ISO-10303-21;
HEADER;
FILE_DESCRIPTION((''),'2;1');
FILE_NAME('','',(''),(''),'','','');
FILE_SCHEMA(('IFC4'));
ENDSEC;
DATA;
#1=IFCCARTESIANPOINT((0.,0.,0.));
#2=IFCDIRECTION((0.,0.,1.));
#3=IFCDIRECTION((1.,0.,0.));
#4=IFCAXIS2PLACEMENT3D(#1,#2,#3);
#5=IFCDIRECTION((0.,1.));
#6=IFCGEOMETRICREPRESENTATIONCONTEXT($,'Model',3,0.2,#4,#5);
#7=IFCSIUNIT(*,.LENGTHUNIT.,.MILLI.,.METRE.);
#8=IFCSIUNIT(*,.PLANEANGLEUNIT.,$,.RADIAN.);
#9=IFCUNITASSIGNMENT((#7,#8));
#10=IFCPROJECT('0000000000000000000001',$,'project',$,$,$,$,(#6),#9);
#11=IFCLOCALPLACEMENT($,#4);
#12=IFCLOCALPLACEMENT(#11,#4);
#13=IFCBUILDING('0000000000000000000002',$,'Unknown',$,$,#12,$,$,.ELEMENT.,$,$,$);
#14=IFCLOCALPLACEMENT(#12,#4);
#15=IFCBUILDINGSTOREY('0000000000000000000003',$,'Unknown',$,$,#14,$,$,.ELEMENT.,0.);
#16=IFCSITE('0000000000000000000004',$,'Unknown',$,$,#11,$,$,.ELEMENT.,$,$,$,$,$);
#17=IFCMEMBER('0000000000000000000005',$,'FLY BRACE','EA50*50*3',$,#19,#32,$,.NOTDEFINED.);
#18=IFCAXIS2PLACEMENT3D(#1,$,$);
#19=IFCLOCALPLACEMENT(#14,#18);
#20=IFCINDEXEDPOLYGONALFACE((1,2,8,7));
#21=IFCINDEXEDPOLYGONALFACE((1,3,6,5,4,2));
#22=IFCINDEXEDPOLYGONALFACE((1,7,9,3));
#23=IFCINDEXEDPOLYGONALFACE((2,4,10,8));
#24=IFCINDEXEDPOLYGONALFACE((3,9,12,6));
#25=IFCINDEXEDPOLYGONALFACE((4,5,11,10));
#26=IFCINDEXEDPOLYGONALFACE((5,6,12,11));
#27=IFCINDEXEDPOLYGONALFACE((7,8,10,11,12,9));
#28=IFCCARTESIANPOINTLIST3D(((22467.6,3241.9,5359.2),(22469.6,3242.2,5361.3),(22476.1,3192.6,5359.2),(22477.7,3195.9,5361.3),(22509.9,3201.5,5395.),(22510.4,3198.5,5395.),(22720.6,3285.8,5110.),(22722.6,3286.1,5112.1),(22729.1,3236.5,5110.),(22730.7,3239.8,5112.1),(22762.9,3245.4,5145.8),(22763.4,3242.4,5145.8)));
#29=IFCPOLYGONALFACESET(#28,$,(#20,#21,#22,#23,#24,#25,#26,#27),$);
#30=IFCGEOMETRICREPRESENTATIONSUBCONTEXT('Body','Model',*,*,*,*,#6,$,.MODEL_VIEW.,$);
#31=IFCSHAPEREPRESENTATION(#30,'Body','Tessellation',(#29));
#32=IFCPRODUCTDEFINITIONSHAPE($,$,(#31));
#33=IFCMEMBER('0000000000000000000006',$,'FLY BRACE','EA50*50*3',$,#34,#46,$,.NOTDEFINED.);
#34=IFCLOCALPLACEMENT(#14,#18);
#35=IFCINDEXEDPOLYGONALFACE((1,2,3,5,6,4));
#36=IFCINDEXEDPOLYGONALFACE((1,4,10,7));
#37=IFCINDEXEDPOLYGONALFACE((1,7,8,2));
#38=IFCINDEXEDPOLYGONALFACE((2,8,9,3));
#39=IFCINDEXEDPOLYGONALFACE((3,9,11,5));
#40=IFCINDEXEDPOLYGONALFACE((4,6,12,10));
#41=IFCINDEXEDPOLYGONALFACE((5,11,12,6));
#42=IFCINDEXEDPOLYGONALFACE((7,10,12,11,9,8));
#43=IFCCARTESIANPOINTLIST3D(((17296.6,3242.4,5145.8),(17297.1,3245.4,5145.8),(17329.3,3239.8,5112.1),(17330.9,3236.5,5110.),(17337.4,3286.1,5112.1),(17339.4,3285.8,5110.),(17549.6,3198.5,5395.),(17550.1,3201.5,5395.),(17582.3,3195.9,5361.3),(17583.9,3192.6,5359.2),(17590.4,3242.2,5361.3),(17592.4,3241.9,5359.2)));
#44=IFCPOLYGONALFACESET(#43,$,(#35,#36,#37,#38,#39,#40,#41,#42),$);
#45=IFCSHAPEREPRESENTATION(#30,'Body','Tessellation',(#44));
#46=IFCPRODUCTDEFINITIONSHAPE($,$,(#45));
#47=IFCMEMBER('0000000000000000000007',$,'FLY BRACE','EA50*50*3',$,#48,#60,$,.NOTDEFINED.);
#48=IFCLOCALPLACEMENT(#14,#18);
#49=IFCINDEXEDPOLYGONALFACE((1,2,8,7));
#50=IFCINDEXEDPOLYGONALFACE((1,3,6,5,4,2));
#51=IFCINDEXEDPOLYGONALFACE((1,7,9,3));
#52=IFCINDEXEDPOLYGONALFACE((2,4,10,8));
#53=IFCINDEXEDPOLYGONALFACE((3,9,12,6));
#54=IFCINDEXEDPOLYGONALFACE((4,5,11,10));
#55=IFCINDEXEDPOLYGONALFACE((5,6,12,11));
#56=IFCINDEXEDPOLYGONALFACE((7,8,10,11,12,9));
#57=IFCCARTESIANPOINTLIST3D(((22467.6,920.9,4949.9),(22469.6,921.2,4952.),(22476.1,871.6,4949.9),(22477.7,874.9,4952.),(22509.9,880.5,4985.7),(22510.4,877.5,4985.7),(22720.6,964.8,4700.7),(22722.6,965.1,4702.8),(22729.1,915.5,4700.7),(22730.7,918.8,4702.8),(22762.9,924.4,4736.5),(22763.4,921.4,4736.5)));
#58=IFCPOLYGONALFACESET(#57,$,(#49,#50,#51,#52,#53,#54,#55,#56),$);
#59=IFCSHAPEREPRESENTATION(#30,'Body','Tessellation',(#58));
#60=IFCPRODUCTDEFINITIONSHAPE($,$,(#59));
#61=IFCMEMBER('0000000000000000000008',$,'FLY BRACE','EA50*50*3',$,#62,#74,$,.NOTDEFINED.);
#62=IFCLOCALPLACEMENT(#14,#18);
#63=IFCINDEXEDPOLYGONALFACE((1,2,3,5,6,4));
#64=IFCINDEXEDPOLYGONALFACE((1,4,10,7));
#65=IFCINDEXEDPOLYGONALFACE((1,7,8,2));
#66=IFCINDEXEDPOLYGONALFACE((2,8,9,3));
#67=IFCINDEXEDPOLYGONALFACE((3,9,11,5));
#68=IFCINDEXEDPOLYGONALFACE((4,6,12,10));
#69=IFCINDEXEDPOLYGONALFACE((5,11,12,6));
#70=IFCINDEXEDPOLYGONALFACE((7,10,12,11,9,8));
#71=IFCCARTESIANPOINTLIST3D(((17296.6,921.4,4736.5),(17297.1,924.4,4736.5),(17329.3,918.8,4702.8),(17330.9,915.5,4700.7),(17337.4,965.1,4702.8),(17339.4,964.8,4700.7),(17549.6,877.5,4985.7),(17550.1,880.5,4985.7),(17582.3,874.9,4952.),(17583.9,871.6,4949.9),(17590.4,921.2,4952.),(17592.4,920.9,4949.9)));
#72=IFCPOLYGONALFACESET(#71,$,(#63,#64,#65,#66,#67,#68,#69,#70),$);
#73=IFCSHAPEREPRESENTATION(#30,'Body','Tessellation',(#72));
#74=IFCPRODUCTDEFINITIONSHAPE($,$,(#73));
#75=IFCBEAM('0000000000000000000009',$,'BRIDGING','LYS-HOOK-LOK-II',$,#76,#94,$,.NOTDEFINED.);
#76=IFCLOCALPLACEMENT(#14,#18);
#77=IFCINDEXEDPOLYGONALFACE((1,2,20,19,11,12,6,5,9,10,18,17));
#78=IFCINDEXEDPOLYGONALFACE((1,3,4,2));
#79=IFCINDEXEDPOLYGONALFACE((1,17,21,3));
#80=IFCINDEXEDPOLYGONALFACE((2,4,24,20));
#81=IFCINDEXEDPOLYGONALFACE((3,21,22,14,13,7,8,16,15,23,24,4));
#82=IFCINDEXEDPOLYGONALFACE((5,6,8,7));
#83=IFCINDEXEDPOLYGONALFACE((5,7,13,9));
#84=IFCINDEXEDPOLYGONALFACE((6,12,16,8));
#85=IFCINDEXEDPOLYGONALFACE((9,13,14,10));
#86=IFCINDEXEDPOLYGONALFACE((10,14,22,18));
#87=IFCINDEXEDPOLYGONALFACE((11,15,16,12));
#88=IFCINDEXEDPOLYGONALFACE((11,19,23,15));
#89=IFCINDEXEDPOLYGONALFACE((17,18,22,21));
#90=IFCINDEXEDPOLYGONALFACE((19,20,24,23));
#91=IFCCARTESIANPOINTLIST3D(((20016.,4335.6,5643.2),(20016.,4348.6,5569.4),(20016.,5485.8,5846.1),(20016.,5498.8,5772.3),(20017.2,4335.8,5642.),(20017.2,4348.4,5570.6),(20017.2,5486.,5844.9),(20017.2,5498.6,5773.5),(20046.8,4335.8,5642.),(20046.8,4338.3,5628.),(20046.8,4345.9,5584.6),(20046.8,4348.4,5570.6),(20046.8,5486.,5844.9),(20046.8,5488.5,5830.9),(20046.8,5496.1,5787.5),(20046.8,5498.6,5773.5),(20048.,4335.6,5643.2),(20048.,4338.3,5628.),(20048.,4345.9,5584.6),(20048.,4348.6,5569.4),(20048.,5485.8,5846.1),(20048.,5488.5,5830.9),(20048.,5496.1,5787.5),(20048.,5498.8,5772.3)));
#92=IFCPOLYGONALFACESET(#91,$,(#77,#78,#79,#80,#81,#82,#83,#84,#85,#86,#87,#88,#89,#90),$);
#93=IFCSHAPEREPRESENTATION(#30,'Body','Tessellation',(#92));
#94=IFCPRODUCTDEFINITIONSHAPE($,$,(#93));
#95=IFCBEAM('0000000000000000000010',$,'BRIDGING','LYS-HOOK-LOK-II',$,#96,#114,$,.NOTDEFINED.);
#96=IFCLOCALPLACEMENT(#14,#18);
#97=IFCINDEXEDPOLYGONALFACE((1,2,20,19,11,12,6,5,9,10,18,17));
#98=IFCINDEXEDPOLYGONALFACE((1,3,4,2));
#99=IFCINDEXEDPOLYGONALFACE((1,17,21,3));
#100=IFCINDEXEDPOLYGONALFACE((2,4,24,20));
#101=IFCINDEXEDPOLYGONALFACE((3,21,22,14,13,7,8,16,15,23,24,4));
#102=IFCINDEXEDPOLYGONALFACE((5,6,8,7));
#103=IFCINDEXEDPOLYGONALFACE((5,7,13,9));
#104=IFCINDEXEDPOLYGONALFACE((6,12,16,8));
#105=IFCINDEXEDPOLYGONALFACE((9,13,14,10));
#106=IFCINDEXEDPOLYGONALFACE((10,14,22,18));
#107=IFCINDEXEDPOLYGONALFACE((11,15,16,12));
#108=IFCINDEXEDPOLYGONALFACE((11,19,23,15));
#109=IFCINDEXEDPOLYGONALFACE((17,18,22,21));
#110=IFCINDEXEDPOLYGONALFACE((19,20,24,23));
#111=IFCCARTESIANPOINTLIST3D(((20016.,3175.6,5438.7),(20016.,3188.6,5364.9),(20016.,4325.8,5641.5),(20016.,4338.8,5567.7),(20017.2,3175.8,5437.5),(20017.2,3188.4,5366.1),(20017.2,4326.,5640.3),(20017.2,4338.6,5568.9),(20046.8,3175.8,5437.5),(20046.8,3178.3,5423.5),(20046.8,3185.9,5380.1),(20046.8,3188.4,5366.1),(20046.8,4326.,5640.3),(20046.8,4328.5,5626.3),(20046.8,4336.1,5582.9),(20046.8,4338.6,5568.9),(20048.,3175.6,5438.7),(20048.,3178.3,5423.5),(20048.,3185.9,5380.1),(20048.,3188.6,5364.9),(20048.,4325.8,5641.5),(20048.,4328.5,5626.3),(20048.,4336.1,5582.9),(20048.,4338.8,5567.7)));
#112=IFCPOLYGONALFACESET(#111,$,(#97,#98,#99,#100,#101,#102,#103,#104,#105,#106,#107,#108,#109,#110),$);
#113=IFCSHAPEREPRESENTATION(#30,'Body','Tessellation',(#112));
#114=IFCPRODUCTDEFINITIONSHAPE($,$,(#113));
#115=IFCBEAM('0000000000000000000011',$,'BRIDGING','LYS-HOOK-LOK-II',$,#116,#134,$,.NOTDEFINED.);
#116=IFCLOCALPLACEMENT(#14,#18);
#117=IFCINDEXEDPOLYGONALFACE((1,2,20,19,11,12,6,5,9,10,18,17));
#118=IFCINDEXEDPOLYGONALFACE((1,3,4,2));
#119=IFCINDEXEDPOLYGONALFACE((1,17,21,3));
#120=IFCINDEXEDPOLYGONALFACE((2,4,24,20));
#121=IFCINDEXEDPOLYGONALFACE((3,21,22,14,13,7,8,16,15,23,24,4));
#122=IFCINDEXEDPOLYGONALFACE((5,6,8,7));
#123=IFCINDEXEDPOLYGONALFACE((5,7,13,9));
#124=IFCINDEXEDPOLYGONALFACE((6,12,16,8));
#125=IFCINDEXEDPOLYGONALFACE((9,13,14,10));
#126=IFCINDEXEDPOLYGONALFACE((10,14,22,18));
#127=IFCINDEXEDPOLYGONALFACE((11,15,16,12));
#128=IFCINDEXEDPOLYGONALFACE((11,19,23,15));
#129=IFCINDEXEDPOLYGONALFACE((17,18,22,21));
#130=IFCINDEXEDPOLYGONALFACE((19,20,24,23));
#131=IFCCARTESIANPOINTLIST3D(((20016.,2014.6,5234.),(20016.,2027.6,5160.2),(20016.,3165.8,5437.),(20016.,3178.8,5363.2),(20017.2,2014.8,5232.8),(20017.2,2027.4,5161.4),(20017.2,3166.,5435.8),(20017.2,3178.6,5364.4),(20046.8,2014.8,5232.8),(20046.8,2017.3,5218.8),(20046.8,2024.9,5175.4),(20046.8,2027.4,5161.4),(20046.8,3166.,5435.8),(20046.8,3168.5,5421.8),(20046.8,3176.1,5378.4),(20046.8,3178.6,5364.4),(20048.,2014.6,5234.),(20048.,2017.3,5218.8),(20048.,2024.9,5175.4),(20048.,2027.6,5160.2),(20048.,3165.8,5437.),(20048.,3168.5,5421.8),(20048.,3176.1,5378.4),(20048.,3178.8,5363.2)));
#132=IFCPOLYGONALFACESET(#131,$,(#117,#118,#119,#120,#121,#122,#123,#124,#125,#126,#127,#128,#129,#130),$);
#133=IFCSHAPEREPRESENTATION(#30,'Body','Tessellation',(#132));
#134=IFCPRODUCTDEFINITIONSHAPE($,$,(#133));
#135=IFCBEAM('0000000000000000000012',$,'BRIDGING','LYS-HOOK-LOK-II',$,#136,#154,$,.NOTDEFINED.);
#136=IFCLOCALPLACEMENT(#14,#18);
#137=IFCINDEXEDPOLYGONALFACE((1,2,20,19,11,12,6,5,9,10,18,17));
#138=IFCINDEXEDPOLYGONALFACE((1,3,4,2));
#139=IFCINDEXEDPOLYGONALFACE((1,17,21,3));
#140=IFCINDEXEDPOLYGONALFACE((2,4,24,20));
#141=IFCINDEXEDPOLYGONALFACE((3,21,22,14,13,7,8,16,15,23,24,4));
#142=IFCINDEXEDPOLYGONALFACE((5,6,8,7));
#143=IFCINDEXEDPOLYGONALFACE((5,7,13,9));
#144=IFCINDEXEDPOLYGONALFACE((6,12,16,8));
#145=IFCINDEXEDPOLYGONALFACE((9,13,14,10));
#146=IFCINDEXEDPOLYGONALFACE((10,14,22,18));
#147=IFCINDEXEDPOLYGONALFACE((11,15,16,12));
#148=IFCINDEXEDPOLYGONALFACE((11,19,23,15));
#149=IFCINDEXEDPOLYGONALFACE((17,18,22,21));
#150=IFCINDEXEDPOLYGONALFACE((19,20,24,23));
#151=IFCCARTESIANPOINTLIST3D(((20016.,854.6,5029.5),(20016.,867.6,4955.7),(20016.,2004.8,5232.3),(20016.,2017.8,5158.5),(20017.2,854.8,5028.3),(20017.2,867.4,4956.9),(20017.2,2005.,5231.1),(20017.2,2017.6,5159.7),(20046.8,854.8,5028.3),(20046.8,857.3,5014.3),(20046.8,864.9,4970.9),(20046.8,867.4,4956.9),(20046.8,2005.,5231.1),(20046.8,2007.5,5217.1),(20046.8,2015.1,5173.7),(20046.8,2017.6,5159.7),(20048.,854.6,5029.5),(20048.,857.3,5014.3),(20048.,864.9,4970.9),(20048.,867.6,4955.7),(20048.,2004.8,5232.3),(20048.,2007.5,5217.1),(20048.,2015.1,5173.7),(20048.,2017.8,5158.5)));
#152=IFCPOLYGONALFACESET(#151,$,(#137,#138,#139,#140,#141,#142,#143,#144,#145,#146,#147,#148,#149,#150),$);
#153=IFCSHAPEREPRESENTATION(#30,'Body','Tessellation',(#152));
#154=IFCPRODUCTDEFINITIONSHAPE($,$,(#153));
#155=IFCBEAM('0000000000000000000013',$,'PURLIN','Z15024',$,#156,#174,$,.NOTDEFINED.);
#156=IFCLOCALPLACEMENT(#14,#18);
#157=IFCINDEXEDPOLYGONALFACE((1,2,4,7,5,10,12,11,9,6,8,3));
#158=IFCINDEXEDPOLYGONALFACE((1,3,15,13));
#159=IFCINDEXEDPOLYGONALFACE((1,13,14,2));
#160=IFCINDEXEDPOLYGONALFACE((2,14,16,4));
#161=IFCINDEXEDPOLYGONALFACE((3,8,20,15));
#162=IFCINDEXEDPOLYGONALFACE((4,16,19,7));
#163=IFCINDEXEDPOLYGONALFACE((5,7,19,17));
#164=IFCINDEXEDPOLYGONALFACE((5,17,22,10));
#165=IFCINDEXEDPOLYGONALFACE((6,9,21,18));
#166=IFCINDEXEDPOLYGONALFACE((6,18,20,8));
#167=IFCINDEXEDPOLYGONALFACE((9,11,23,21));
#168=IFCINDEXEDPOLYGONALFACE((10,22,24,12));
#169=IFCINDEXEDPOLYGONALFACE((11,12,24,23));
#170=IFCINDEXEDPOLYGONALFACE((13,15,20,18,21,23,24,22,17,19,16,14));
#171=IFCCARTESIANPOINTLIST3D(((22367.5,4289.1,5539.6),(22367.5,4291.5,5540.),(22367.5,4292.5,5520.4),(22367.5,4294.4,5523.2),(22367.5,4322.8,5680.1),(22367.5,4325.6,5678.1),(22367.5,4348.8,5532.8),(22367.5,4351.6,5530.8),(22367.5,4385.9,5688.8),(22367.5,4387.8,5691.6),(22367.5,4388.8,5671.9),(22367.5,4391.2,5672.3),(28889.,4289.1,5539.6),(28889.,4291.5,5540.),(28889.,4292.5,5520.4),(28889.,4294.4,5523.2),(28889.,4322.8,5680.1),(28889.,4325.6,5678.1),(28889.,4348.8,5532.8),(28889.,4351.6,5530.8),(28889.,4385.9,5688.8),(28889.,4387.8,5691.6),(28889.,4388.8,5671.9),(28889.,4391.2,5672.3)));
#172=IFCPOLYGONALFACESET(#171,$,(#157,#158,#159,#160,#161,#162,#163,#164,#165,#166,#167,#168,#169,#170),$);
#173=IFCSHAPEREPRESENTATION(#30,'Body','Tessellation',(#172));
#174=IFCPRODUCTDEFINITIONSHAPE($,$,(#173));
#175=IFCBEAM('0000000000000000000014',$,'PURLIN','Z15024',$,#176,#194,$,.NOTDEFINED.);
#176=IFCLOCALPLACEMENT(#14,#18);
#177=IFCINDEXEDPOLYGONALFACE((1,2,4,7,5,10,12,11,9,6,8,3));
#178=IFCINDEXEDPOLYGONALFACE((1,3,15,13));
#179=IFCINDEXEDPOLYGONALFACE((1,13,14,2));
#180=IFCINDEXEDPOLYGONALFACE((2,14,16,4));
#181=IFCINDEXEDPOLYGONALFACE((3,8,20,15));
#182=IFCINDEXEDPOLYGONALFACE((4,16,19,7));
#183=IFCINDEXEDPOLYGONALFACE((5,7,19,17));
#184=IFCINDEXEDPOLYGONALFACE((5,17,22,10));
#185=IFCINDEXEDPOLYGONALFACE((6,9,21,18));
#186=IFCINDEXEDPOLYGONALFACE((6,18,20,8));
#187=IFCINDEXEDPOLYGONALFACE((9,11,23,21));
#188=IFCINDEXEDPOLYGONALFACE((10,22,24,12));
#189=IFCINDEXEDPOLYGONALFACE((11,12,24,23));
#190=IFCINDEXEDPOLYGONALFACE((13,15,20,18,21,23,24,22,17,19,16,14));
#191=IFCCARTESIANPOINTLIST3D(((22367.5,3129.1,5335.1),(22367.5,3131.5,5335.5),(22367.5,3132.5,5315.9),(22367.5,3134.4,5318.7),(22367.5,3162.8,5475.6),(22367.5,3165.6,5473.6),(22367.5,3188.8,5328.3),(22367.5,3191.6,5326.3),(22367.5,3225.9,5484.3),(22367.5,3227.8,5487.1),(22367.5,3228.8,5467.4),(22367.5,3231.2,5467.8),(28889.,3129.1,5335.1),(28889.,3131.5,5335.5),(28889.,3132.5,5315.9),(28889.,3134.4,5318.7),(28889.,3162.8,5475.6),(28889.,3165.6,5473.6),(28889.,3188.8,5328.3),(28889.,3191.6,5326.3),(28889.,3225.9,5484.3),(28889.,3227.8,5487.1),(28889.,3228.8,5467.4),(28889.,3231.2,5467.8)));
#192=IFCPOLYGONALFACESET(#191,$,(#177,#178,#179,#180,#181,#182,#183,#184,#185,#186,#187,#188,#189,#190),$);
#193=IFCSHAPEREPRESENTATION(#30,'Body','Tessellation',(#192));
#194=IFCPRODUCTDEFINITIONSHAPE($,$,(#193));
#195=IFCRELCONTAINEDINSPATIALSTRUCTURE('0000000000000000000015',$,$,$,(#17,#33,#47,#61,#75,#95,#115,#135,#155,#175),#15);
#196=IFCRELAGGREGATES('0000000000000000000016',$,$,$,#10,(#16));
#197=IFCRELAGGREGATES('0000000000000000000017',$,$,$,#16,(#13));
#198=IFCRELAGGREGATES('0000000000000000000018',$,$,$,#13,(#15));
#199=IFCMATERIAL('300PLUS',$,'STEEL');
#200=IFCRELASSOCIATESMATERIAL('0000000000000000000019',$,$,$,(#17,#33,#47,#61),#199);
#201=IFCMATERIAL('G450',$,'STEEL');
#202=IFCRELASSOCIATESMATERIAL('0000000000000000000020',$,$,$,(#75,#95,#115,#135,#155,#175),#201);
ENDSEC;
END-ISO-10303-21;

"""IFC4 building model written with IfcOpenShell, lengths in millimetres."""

from ifc_helpers import new_model, si_unit, direction, frame, origin_with_axes, place, context, subcontext, project, spatial, line, indexed_curve, outline, extrude, material, element, save


model = new_model("IFC4")

# Units and contexts
model_context = context("Model", 3, precision=0.2, world=origin_with_axes(), true_north=direction((0.0, 1.0)))
body_context = subcontext(model_context, "Body", "Model", "MODEL_VIEW")
ifc_project = project(units=[si_unit("LENGTHUNIT", "METRE", prefix="MILLI"), si_unit("PLANEANGLEUNIT", "RADIAN")], contexts=[model_context])

# Site, building, storey
site_placement = place(None, origin_with_axes())
site = spatial("IfcSite", under=ifc_project, at=site_placement, Name="Unknown", CompositionType="ELEMENT")
building_placement = place(site_placement, origin_with_axes())
building = spatial("IfcBuilding", under=site, at=building_placement, Name="Unknown", CompositionType="ELEMENT")
storey_placement = place(building_placement, origin_with_axes())
storey = spatial("IfcBuildingStorey", under=building, at=storey_placement, Name="Unknown", CompositionType="ELEMENT", Elevation=0.0)

# Members
ifc_material_1 = material(Name="300PLUS", Category="STEEL")
for number, where, z_axis, x_axis, name in (
    (1, (22489.0, 3220.2, 5377.1), (0.686182, 0.119065, 0.71762), (0.707055, 0.122687, -0.696435), "FLY BRACE"),
    (2, (17571.0, 3220.2, 5377.1), (0.170963, 0.985277, 0.0), (-0.707055, 0.122687, -0.696435), "FLY BRACE"),
    (3, (22489.0, 899.2, 4967.8), (0.686182, 0.119065, 0.71762), (0.707055, 0.122687, -0.696435), "FLY BRACE"),
    (4, (17571.0, 899.2, 4967.8), (0.170963, 0.985277, 0.0), (-0.707055, 0.122687, -0.696435), "FLY BRACE"),
):
    element("IfcMember", number, at=place(storey_placement, frame(where, z_axis=z_axis, x_axis=x_axis)), inside=storey, material=ifc_material_1, Name=name, Description="EA50*50*3", PredefinedType="NOTDEFINED", context=body_context, shape_type="SolidModel", body=[
        extrude(outline(indexed_curve([(-25.0, -25.0), (25.0, -25.0), (25.0, -22.0), (-22.0, -22.0), (-22.0, 25.0), (-25.0, 25.0)], segments=[line(1, 2, 3, 4, 5, 6, 1)])), frame((0.0, 0.0, 0.0), z_axis=(-1.0, 0.0, 0.0), x_axis=(0.0, 0.0, 1.0)), (0.0, 0.0, -1.0), 357.8),
    ])

# Beams
ifc_material_2 = material(Name="G450", Category="STEEL")
beam_1_placement = place(storey_placement, frame((20032.0, 4342.1, 5606.3), z_axis=(1.0, 0.0, 0.0), x_axis=(0.0, 0.984795, 0.173722)))
element("IfcBeam", 5, at=beam_1_placement, inside=storey, material=ifc_material_2, Name="BRIDGING", Description="LYS-HOOK-LOK-II", PredefinedType="NOTDEFINED", context=body_context, shape_type="SolidModel", body=[
    extrude(outline(indexed_curve([(16.0, -37.5), (16.0, -22.0), (14.8, -22.0), (14.8, -36.3), (-14.8, -36.3), (-14.8, 36.3), (14.8, 36.3), (14.8, 22.0), (16.0, 22.0), (16.0, 37.5), (-16.0, 37.5), (-16.0, -37.5)], segments=[line(1, 2, 3, 4, 5, 6, 7, 8, 9, 10, 11, 12, 1)])), frame((0.0, 0.0, 0.0), z_axis=(-1.0, 0.0, 0.0), x_axis=(0.0, 0.0, 1.0)), (0.0, 0.0, -1.0), 1168.0),
])
beam_2_placement = place(storey_placement, frame((20032.0, 3182.1, 5401.8), z_axis=(1.0, 0.0, 0.0), x_axis=(0.0, 0.984809, 0.173639)))
element("IfcBeam", 6, at=beam_2_placement, inside=storey, material=ifc_material_2, Name="BRIDGING", Description="LYS-HOOK-LOK-II", PredefinedType="NOTDEFINED", context=body_context, shape_type="SolidModel", body=[
    extrude(outline(indexed_curve([(16.0, -37.5), (16.0, -22.0), (14.8, -22.0), (14.8, -36.3), (-14.8, -36.3), (-14.8, 36.3), (14.8, 36.3), (14.8, 22.0), (16.0, 22.0), (16.0, 37.5), (-16.0, 37.5), (-16.0, -37.5)], segments=[line(1, 2, 3, 4, 5, 6, 7, 8, 9, 10, 11, 12, 1)])), frame((0.0, 0.0, 0.0), z_axis=(-1.0, 0.0, 0.0), x_axis=(0.0, 0.0, 1.0)), (0.0, 0.0, -1.0), 1167.9),
])
beam_3_placement = place(storey_placement, frame((20032.0, 2021.1, 5197.1), z_axis=(1.0, 0.0, 0.0), x_axis=(0.0, 0.984806, 0.173658)))
element("IfcBeam", 7, at=beam_3_placement, inside=storey, material=ifc_material_2, Name="BRIDGING", Description="LYS-HOOK-LOK-II", PredefinedType="NOTDEFINED", context=body_context, shape_type="SolidModel", body=[
    extrude(outline(indexed_curve([(16.0, -37.5), (16.0, -22.0), (14.8, -22.0), (14.8, -36.3), (-14.8, -36.3), (-14.8, 36.3), (14.8, 36.3), (14.8, 22.0), (16.0, 22.0), (16.0, 37.5), (-16.0, 37.5), (-16.0, -37.5)], segments=[line(1, 2, 3, 4, 5, 6, 7, 8, 9, 10, 11, 12, 1)])), frame((0.0, 0.0, 0.0), z_axis=(-1.0, 0.0, 0.0), x_axis=(0.0, 0.0, 1.0)), (0.0, 0.0, -1.0), 1169.0),
])
beam_4_placement = place(storey_placement, frame((20032.0, 861.1, 4992.6), z_axis=(1.0, 0.0, 0.0), x_axis=(0.0, 0.984809, 0.173639)))
element("IfcBeam", 8, at=beam_4_placement, inside=storey, material=ifc_material_2, Name="BRIDGING", Description="LYS-HOOK-LOK-II", PredefinedType="NOTDEFINED", context=body_context, shape_type="SolidModel", body=[
    extrude(outline(indexed_curve([(16.0, -37.5), (16.0, -22.0), (14.8, -22.0), (14.8, -36.3), (-14.8, -36.3), (-14.8, 36.3), (14.8, 36.3), (14.8, 22.0), (16.0, 22.0), (16.0, 37.5), (-16.0, 37.5), (-16.0, -37.5)], segments=[line(1, 2, 3, 4, 5, 6, 7, 8, 9, 10, 11, 12, 1)])), frame((0.0, 0.0, 0.0), z_axis=(-1.0, 0.0, 0.0), x_axis=(0.0, 0.0, 1.0)), (0.0, 0.0, -1.0), 1167.9),
])
for number, where, z_axis, x_axis, name in (
    (9, (22367.5, 4337.2, 5605.5), (0.0, -0.984808, -0.173648), (1.0, 0.0, 0.0), "PURLIN"),
    (10, (22367.5, 3177.2, 5401.0), (0.0, -0.984808, -0.173648), (1.0, 0.0, 0.0), "PURLIN"),
):
    element("IfcBeam", number, at=place(storey_placement, frame(where, z_axis=z_axis, x_axis=x_axis)), inside=storey, material=ifc_material_2, Name=name, Description="Z15024", PredefinedType="NOTDEFINED", context=body_context, shape_type="SolidModel", body=[
        extrude(outline(indexed_curve([(58.8, -76.0), (58.8, -56.5), (56.4, -56.5), (56.4, -73.6), (1.2, -73.6), (1.2, 76.0), (-64.8, 76.0), (-64.8, 56.5), (-62.4, 56.5), (-62.4, 73.6), (-1.2, 73.6), (-1.2, -76.0)], segments=[line(1, 2, 3, 4, 5, 6, 7, 8, 9, 10, 11, 12, 1)])), frame((0.0, 0.0, 0.0), z_axis=(-1.0, 0.0, 0.0), x_axis=(0.0, 0.0, 1.0)), (0.0, 0.0, -1.0), 6521.5),
    ])

save(model, "model.ifc")
